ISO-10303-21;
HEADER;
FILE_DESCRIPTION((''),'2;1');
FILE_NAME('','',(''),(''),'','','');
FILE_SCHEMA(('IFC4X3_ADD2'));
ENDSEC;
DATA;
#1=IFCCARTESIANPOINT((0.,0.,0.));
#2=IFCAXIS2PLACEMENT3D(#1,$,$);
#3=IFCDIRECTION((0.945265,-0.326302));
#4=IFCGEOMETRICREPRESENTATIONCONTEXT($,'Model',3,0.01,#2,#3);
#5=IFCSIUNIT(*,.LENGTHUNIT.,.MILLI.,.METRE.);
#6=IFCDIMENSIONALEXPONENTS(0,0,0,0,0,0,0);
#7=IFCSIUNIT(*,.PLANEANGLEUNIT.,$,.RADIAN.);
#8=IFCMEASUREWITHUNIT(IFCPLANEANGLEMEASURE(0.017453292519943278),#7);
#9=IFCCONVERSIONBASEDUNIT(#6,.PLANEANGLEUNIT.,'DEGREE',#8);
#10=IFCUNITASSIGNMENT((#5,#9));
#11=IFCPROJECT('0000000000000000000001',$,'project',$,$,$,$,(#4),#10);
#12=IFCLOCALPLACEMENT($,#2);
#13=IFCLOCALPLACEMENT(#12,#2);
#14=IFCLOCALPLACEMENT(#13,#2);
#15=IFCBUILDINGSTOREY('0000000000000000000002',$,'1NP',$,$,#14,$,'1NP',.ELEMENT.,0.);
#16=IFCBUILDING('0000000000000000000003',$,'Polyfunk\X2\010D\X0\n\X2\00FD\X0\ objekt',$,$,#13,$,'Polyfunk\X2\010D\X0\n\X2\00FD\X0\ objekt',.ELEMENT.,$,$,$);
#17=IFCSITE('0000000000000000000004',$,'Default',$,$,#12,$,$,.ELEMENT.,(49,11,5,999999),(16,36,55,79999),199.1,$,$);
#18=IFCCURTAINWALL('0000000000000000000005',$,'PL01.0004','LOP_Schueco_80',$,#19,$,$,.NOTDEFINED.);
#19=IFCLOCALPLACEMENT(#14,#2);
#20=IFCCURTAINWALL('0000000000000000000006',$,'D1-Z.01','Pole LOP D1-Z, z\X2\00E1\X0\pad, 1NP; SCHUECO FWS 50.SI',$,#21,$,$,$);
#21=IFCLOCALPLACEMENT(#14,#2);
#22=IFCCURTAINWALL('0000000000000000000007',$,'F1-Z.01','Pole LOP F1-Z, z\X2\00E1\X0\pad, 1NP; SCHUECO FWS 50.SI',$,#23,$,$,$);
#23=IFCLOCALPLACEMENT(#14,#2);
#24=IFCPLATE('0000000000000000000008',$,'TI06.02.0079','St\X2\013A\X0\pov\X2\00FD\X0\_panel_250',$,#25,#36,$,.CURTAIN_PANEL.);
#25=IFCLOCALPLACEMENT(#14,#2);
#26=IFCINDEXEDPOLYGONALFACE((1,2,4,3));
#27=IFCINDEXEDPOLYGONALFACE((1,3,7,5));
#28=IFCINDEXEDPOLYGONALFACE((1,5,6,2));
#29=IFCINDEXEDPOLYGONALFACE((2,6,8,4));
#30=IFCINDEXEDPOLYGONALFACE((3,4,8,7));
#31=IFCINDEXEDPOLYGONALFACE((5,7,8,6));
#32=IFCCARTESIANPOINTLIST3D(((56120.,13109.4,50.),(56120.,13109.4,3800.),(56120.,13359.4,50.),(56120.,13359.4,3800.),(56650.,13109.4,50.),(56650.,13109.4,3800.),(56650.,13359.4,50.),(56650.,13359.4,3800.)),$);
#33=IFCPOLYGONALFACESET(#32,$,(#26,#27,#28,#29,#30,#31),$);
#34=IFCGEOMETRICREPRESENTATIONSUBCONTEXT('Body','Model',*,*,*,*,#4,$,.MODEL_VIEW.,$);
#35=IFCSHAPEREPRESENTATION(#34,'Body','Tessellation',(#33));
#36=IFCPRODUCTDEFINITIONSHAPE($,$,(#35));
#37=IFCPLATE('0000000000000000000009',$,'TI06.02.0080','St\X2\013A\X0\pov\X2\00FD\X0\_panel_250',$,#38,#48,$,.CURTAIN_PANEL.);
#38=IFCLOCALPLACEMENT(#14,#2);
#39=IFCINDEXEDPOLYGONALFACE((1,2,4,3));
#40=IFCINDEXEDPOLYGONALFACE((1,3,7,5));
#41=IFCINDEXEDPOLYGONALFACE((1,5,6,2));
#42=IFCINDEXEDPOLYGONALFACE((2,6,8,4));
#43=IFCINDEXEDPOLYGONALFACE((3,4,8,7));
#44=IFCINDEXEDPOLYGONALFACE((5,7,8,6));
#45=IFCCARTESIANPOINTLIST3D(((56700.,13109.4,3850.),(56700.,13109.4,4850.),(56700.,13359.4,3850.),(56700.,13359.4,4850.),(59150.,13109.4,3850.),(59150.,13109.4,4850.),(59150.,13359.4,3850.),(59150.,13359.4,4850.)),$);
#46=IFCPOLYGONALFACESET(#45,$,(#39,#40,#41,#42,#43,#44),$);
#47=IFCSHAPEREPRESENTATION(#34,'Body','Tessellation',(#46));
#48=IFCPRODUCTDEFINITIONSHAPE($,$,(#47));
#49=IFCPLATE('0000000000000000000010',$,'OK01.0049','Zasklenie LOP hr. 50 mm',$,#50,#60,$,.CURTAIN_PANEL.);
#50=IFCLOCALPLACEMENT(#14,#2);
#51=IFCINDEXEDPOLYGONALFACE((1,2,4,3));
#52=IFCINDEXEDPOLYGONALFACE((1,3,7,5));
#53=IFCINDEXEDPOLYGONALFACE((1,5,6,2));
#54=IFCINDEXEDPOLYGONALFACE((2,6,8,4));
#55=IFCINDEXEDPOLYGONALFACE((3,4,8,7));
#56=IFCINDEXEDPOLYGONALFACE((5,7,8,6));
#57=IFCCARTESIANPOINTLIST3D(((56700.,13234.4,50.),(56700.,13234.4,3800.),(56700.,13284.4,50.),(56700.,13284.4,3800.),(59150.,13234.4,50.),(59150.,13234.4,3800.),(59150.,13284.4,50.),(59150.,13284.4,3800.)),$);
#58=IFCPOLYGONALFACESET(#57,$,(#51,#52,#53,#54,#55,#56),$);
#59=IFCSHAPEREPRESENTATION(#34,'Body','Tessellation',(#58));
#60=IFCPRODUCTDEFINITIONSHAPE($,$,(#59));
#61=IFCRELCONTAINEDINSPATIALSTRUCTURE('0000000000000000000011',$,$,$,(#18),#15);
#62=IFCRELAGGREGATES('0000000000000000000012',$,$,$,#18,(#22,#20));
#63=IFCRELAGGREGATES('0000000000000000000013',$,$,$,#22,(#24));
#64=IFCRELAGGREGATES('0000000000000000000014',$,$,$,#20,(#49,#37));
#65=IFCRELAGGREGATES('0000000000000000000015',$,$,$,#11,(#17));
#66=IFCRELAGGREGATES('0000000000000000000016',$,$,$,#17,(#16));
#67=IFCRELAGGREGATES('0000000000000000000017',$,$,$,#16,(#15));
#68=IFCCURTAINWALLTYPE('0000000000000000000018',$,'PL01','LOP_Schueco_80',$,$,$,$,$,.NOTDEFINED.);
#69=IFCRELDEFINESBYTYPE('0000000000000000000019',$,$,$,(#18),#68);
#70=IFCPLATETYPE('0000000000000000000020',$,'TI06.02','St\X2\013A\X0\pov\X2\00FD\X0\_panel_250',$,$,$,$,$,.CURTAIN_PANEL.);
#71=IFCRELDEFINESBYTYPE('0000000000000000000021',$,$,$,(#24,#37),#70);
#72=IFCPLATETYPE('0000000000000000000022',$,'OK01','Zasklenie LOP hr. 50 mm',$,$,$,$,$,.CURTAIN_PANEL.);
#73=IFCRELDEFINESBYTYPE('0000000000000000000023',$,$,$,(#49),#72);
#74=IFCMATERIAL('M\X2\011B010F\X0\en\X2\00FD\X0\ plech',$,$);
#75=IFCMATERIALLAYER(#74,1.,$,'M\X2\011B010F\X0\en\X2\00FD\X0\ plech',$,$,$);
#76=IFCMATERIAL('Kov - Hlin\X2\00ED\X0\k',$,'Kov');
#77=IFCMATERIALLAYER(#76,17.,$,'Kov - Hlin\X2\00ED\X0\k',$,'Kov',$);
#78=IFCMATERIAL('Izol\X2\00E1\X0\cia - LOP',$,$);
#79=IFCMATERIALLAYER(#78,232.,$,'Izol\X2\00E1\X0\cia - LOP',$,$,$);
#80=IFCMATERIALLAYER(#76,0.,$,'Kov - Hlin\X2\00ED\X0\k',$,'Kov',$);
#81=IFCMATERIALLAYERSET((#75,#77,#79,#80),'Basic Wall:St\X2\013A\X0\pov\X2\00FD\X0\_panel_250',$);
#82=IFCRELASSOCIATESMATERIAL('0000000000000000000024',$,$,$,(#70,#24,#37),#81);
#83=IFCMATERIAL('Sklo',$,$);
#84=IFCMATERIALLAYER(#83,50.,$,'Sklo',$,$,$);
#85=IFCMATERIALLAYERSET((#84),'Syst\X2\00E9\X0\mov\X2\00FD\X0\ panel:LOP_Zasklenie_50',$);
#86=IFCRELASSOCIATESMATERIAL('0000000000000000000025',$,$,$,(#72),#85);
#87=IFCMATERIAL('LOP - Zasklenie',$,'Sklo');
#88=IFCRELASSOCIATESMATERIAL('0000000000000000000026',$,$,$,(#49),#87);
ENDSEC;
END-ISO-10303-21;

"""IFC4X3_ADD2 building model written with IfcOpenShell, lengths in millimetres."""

from ifc_helpers import new_model, entity, si_unit, converted_unit, direction, frame, frame_2d, origin, place, context, subcontext, project, spatial, rectangle, extrude, source, transform, mapped, material, layer, layer_set, layer_usage, type_object, type_shapes, element, aggregate, save


model = new_model("IFC4X3_ADD2")

# Units and contexts
model_context = context("Model", 3, precision=0.01, world=origin(), true_north=direction((0.945265, -0.326302)))
body_context = subcontext(model_context, "Body", "Model", "MODEL_VIEW")
ifc_project = project(units=[si_unit("LENGTHUNIT", "METRE", prefix="MILLI"), converted_unit("PLANEANGLEUNIT", "DEGREE", entity("IfcPlaneAngleMeasure", 0.017453292519943278), si_unit("PLANEANGLEUNIT", "RADIAN"), dimensions=[0, 0, 0, 0, 0, 0, 0])], contexts=[model_context])

# Site, building, storey
site_placement = place(None, origin())
site = spatial("IfcSite", under=ifc_project, at=site_placement, Name="Default", CompositionType="ELEMENT", RefLatitude=(49, 11, 5, 999999), RefLongitude=(16, 36, 55, 79999), RefElevation=199.1)
building_placement = place(site_placement, origin())
building = spatial("IfcBuilding", under=site, at=building_placement, Name="Polyfunkčný objekt", LongName="Polyfunkčný objekt", CompositionType="ELEMENT")
storey_placement = place(building_placement, origin())
storey = spatial("IfcBuildingStorey", under=building, at=storey_placement, Name="1NP", LongName="1NP", CompositionType="ELEMENT", Elevation=0.0)

# Curtain walls, plates
curtain_wall_type = type_object("IfcCurtainWallType", Name="PL01", Description="LOP_Schueco_80", PredefinedType="NOTDEFINED")
curtain_wall_1_placement = place(storey_placement, origin())
curtain_wall_1 = element("IfcCurtainWall", 1, at=curtain_wall_1_placement, inside=storey, type_object=curtain_wall_type, Name="PL01.0004", Description="LOP_Schueco_80", PredefinedType="NOTDEFINED")
curtain_wall_2 = element("IfcCurtainWall", 2, Name="D1-Z.01", Description="Pole LOP D1-Z, západ, 1NP; SCHUECO FWS 50.SI")
curtain_wall_3 = element("IfcCurtainWall", 3, Name="F1-Z.01", Description="Pole LOP F1-Z, západ, 1NP; SCHUECO FWS 50.SI")
aggregate(curtain_wall_1, [curtain_wall_3, curtain_wall_2])
ifc_material_1 = material(Name="Měďený plech")
ifc_layer_1 = layer(ifc_material_1, 1.0, Name="Měďený plech")
ifc_material_2 = material(Name="Kov - Hliník", Category="Kov")
ifc_layer_2 = layer(ifc_material_2, 17.0, Name="Kov - Hliník", Category="Kov")
ifc_material_3 = material(Name="Izolácia - LOP")
ifc_layer_3 = layer(ifc_material_3, 232.0, Name="Izolácia - LOP")
ifc_layer_4 = layer(ifc_material_2, 0.0, Name="Kov - Hliník", Category="Kov")
ifc_layer_set_1 = layer_set([ifc_layer_1, ifc_layer_2, ifc_layer_3, ifc_layer_4], Name="Basic Wall:Stĺpový_panel_250")
ifc_layer_usage_1 = layer_usage(ifc_layer_set_1, "AXIS2", "NEGATIVE", 125.0)
plate_type_1 = type_object("IfcPlateType", Name="TI06.02", Description="Stĺpový_panel_250", PredefinedType="CURTAIN_PANEL", material=ifc_layer_set_1)
plate_1_placement = place(storey_placement, frame((56120.0, 13234.4, 50.0)))
plate_1 = element("IfcPlate", 4, at=plate_1_placement, type_object=plate_type_1, material=ifc_layer_usage_1, Name="TI06.02.0079", Description="Stĺpový_panel_250", PredefinedType="CURTAIN_PANEL", context=body_context, shape_type="SweptSolid", body=[
    extrude(rectangle(XDim=250.0, YDim=530.0, at=frame_2d((0.0, 0.0), x_axis=(1.0, 0.0))), frame((265.0, 0.0, 0.0), z_axis=(0.0, 0.0, 1.0), x_axis=(0.0, 1.0, 0.0)), (0.0, 0.0, 1.0), 3750.0),
])
aggregate(curtain_wall_3, [plate_1])
ifc_layer_usage_2 = layer_usage(ifc_layer_set_1, "AXIS2", "NEGATIVE", 125.0)
plate_2_placement = place(storey_placement, frame((56700.0, 13234.4, 3850.0)))
plate_2 = element("IfcPlate", 5, at=plate_2_placement, type_object=plate_type_1, material=ifc_layer_usage_2, Name="TI06.02.0080", Description="Stĺpový_panel_250", PredefinedType="CURTAIN_PANEL", context=body_context, shape_type="SweptSolid", body=[
    extrude(rectangle(XDim=250.0, YDim=2450.0, at=frame_2d((0.0, 0.0), x_axis=(1.0, 0.0))), frame((1225.0, 0.0, 0.0), z_axis=(0.0, 0.0, 1.0), x_axis=(0.0, 1.0, 0.0)), (0.0, 0.0, 1.0), 1000.0),
])
ifc_material_4 = material(Name="LOP - Zasklenie", Category="Sklo")
ifc_material_5 = material(Name="Sklo")
ifc_layer_5 = layer(ifc_material_5, 50.0, Name="Sklo")
ifc_layer_set_2 = layer_set([ifc_layer_5], Name="Systémový panel:LOP_Zasklenie_50")
plate_type_2 = type_object("IfcPlateType", Name="OK01", Description="Zasklenie LOP hr. 50 mm", PredefinedType="CURTAIN_PANEL", material=ifc_layer_set_2)
shared_shape_1 = source(origin(), body_context, "Body", "SweptSolid", [
    extrude(rectangle(XDim=3750.0, YDim=2450.0, at=frame_2d((-141.7, 0.0), x_axis=(1.0, 0.0))), frame((0.0, 0.0, 2016.7), z_axis=(0.0, 1.0, 0.0), x_axis=(0.0, 0.0, 1.0)), (0.0, 0.0, 1.0), 50.0),
])
type_shapes(plate_type_2, [shared_shape_1])
plate_3_placement = place(curtain_wall_1_placement, frame((57925.0, 13234.4, 50.0)))
plate_3 = element("IfcPlate", 6, at=plate_3_placement, type_object=plate_type_2, material=ifc_material_4, Name="OK01.0049", Description="Zasklenie LOP hr. 50 mm", PredefinedType="CURTAIN_PANEL", context=body_context, shape_type="MappedRepresentation", body=[
    mapped(shared_shape_1, transform((0.0, 0.0, 0.0), scale=1.0)),
])
aggregate(curtain_wall_2, [plate_3, plate_2])

save(model, "model.ifc")
